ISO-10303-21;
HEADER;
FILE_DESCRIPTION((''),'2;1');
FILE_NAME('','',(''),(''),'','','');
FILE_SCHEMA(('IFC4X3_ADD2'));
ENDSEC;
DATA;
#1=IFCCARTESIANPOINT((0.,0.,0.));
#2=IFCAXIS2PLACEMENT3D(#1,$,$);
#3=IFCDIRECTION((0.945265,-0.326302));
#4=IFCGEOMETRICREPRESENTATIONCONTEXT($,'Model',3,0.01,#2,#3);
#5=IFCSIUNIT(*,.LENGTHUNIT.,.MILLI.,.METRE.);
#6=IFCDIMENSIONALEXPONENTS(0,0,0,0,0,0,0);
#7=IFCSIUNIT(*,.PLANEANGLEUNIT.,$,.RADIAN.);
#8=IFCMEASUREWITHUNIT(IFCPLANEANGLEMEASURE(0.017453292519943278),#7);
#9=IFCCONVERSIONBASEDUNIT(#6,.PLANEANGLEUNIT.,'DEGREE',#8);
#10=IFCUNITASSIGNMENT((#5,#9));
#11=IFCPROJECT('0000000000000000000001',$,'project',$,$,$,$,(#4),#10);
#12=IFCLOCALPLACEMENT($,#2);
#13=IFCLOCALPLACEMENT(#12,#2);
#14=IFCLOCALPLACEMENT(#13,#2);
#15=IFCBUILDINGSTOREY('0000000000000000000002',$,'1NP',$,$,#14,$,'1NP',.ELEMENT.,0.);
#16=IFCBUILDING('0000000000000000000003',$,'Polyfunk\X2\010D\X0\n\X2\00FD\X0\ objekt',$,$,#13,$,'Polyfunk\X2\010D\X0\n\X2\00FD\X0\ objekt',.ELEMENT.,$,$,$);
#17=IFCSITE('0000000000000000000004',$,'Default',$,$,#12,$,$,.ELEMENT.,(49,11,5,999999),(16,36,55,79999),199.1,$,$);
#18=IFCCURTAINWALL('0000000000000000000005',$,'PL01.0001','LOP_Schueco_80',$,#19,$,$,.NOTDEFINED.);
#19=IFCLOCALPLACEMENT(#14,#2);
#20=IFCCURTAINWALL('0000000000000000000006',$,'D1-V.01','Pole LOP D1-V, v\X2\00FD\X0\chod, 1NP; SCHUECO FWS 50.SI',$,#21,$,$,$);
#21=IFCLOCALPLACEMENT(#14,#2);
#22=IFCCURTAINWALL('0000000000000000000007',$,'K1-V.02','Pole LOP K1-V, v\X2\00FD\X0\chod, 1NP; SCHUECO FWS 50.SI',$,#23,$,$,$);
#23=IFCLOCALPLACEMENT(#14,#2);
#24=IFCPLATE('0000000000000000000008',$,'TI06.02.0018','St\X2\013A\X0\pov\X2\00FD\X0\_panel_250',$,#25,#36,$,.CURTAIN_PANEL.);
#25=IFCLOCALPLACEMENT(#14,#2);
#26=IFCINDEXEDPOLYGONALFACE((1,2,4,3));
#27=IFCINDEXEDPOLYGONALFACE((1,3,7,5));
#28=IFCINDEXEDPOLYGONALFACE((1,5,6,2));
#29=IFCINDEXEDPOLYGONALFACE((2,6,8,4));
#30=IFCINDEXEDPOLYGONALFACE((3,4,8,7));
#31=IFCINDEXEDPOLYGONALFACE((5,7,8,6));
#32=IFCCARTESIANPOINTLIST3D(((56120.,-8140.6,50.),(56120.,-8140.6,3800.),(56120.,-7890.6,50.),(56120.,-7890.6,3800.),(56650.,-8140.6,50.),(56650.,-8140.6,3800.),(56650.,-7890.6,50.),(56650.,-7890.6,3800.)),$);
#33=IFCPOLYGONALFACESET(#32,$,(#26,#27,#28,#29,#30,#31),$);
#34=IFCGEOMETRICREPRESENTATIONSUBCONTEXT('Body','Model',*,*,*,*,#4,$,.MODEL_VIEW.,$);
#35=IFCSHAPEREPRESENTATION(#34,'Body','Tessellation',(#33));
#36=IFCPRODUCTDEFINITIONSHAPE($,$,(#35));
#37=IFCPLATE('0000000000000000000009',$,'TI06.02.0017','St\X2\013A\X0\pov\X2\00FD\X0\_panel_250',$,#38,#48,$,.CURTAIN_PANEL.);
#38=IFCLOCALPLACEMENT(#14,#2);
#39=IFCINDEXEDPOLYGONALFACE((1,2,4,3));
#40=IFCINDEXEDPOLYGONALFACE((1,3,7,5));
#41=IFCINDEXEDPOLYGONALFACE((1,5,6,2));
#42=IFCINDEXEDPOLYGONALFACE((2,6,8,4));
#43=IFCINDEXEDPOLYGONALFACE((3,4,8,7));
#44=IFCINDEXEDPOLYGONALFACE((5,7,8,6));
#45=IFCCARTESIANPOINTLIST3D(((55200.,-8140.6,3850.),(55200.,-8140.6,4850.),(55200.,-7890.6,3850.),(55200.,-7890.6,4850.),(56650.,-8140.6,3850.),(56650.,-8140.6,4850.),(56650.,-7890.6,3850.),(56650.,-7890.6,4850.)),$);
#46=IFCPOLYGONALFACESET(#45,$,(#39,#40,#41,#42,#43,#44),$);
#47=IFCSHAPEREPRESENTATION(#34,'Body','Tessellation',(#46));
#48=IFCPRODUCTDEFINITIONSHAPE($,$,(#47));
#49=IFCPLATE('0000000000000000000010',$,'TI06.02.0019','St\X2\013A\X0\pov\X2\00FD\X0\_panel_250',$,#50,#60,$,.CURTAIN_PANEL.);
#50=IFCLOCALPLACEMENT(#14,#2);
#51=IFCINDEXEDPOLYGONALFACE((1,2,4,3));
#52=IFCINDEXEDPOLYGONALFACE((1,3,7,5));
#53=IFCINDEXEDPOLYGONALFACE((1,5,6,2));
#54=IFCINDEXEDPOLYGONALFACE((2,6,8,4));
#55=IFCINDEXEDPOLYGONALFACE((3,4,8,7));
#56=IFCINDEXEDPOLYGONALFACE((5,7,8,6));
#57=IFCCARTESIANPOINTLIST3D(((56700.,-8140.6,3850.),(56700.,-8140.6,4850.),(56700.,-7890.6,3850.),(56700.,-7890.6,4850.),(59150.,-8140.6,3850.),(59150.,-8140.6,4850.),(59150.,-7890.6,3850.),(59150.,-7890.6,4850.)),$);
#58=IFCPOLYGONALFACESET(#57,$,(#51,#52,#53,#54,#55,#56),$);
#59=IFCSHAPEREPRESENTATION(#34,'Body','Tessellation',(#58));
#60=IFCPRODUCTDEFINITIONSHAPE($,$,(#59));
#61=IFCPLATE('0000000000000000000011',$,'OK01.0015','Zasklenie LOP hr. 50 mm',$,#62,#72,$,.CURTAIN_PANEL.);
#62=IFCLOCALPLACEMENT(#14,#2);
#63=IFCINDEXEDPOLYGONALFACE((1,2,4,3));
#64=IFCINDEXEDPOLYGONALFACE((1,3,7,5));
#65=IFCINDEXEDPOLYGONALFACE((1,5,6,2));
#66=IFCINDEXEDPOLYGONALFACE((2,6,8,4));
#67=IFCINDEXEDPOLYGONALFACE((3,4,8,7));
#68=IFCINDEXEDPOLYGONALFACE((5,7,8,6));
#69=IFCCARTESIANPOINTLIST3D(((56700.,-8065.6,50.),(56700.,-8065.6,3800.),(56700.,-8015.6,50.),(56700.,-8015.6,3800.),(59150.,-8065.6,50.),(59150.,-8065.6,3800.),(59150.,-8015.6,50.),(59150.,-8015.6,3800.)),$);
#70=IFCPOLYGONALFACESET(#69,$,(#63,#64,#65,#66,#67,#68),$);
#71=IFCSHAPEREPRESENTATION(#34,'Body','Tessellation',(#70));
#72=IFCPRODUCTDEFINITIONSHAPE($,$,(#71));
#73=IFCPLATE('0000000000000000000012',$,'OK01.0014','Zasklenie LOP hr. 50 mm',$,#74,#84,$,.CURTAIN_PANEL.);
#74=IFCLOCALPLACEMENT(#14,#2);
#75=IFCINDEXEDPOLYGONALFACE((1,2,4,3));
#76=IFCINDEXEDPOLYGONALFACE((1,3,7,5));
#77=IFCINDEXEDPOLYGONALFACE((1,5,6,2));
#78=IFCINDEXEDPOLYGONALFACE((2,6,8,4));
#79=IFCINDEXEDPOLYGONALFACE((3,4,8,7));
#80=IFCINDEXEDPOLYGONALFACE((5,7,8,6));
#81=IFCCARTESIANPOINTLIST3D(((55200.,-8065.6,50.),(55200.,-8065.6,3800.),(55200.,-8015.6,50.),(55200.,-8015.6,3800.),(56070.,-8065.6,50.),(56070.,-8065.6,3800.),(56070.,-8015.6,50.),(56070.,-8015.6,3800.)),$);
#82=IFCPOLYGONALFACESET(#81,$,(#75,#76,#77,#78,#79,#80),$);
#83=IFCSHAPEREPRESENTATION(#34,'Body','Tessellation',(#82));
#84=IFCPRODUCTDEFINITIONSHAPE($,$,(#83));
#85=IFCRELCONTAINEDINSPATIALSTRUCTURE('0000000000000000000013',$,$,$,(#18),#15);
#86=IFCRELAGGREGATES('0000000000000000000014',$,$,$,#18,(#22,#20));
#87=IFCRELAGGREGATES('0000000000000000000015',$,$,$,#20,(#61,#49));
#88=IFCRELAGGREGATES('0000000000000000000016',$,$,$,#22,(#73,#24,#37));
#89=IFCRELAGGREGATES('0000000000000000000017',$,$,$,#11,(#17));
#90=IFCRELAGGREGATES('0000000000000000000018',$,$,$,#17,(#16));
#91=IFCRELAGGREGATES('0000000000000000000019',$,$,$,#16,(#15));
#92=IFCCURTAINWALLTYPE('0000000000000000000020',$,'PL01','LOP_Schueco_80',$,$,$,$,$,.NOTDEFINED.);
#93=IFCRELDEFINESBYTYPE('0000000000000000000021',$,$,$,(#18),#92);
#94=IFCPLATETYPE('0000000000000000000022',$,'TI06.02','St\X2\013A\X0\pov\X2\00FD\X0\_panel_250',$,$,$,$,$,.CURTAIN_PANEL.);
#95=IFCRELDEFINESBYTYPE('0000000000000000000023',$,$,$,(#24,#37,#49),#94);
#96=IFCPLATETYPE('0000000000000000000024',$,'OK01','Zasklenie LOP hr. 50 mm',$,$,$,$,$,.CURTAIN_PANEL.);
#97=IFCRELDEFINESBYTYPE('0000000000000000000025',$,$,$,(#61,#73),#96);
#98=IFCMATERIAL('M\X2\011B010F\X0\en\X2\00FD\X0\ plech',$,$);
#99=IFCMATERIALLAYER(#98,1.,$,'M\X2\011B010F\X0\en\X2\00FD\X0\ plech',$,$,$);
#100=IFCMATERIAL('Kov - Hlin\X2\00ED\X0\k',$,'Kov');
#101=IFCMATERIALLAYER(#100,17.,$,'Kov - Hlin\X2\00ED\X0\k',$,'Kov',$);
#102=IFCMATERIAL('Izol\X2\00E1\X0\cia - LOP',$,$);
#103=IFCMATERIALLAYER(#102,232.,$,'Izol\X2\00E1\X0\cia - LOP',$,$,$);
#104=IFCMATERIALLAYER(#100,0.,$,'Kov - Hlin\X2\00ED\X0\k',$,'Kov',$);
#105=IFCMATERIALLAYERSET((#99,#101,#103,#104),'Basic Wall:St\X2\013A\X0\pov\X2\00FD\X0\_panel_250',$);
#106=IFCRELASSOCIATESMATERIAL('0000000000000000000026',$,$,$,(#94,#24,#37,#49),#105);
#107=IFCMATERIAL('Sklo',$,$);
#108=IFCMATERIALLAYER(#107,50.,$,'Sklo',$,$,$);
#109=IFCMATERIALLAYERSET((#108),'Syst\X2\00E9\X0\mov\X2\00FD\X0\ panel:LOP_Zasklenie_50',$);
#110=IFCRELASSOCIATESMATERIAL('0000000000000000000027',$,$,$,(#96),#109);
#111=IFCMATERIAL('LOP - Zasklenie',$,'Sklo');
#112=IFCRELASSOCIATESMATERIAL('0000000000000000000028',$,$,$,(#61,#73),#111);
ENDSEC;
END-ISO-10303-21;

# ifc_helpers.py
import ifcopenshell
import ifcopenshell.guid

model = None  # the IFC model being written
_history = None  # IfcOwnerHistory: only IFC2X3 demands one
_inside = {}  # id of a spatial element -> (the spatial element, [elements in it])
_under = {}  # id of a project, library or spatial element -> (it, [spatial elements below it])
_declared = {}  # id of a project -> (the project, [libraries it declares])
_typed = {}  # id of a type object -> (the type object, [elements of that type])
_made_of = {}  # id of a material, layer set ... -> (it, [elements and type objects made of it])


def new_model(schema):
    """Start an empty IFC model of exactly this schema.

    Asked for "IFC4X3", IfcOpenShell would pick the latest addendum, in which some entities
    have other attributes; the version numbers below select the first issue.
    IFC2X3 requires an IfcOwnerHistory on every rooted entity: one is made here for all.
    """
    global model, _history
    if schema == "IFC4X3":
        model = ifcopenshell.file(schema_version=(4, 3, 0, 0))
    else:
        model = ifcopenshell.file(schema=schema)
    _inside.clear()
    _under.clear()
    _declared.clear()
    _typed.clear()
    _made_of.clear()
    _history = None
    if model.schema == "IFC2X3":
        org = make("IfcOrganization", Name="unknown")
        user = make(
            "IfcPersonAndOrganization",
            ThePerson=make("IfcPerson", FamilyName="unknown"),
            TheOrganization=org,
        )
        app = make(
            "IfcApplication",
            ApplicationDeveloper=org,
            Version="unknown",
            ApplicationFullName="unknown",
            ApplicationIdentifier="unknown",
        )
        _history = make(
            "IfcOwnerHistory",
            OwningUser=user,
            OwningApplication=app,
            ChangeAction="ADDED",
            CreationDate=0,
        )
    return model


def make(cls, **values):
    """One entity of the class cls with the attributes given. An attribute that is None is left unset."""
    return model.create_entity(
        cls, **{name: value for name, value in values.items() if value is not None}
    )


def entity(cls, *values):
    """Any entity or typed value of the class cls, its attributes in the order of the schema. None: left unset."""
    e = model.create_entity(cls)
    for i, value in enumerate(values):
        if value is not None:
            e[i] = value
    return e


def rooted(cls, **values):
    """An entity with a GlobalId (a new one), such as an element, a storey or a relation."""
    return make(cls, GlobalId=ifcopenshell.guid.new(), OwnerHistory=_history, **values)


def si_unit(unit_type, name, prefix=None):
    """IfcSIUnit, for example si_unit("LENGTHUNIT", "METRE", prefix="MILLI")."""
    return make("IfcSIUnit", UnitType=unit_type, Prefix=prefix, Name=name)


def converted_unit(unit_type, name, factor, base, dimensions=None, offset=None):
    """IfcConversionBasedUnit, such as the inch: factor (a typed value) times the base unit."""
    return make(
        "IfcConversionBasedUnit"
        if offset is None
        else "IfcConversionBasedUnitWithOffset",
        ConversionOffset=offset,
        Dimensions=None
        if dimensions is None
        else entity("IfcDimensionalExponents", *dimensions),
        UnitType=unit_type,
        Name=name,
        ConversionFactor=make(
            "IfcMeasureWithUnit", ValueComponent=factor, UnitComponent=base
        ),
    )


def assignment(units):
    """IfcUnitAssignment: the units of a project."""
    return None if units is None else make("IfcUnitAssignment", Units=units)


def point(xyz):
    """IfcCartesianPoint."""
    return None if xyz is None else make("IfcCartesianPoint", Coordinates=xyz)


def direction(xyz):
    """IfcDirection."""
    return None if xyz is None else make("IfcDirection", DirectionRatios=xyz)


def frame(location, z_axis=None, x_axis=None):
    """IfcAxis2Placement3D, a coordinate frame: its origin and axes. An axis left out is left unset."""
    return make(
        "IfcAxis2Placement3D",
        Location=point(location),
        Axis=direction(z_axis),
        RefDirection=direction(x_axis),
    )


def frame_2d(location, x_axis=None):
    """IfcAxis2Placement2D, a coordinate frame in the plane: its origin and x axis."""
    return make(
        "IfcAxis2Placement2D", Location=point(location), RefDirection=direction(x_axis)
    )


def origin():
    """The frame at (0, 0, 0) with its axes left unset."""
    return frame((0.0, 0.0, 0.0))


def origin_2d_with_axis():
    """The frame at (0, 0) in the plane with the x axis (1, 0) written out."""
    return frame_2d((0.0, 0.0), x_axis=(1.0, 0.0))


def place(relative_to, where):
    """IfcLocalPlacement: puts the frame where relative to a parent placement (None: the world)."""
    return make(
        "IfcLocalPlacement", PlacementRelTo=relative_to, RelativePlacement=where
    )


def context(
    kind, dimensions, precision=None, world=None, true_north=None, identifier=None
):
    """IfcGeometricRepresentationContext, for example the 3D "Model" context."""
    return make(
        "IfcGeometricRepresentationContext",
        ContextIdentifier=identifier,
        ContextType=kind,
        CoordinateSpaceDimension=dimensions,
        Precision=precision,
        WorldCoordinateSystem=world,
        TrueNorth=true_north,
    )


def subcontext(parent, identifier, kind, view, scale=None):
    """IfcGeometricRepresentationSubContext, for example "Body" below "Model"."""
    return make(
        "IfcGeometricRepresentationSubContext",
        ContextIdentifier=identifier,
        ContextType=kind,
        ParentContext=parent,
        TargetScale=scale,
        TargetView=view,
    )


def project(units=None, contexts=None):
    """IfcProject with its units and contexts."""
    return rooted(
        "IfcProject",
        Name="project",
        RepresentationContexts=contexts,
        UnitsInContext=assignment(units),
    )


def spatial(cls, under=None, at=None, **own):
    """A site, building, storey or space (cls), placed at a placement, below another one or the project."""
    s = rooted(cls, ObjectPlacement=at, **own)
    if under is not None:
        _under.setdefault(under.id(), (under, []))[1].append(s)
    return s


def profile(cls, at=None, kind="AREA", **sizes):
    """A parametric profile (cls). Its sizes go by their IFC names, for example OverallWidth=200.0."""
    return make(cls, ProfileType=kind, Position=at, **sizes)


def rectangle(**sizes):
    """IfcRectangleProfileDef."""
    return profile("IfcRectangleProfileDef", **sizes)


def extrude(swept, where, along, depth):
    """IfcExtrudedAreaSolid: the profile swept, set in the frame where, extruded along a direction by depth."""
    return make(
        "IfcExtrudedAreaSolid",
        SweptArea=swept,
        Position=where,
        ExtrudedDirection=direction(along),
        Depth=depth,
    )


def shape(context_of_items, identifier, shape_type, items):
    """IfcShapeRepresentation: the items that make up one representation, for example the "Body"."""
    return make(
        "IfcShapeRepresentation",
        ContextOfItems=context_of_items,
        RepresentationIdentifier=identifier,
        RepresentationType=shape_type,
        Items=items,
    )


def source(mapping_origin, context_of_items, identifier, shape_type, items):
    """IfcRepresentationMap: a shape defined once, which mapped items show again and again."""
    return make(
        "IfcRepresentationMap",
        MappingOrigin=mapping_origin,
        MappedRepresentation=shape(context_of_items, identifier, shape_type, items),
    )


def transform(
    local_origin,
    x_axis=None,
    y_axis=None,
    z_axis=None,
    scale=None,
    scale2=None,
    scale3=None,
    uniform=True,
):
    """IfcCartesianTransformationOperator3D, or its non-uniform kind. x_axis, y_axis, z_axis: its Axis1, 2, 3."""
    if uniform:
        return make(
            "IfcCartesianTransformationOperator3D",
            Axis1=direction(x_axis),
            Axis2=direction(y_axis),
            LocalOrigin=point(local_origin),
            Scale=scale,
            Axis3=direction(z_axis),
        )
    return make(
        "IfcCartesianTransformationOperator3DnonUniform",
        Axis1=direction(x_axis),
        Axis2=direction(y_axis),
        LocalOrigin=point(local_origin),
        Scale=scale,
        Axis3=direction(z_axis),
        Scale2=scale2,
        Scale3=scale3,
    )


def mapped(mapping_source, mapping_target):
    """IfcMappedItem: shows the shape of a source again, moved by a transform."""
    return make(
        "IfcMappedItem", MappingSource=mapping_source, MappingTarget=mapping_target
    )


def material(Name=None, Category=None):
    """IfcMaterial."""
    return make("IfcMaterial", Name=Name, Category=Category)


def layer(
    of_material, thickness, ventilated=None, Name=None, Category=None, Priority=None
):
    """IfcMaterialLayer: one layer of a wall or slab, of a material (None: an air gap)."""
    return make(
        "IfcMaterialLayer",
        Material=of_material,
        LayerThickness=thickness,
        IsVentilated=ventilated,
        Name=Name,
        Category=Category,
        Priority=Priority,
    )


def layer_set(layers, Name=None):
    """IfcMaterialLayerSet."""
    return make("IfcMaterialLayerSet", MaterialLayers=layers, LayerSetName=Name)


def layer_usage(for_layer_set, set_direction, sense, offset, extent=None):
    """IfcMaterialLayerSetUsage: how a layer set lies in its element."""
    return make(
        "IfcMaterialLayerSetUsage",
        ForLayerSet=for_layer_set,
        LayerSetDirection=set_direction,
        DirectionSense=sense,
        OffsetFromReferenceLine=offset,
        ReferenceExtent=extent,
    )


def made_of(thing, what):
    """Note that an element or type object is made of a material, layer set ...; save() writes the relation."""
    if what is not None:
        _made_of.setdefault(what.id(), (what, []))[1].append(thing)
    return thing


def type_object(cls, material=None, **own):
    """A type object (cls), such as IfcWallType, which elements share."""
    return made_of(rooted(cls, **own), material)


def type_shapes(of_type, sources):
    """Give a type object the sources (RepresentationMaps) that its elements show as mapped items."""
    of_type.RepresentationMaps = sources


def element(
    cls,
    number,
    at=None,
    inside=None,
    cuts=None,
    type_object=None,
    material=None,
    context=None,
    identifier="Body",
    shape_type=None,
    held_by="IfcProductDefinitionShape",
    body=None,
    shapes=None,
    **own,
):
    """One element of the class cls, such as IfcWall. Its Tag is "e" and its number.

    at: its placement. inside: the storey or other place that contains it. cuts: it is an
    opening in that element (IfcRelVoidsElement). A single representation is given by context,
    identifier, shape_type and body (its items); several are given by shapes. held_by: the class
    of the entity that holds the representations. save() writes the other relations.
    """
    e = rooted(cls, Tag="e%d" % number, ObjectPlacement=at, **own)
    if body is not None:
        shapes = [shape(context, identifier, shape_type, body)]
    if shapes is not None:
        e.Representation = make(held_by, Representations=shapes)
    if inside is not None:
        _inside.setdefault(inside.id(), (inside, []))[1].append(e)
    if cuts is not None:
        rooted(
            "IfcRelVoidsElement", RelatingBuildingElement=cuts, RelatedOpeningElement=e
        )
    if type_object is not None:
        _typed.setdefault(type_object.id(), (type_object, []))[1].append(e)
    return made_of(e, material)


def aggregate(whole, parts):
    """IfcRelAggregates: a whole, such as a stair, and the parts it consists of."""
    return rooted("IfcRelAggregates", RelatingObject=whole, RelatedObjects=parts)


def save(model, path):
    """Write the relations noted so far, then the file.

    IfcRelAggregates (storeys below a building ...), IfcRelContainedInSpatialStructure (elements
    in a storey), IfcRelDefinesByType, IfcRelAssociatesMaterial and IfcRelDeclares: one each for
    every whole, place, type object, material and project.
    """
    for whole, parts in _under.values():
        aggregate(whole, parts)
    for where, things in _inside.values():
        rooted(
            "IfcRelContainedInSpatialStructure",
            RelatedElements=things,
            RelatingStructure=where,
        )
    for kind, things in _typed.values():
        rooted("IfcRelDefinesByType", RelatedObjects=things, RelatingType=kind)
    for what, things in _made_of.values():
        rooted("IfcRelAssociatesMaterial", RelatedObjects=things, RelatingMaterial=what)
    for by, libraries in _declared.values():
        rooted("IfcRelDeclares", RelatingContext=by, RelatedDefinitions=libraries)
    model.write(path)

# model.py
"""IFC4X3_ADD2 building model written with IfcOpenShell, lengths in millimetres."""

from ifc_helpers import new_model, entity, si_unit, converted_unit, direction, frame, frame_2d, origin, origin_2d_with_axis, place, context, subcontext, project, spatial, rectangle, extrude, source, transform, mapped, material, layer, layer_set, layer_usage, type_object, type_shapes, element, aggregate, save


model = new_model("IFC4X3_ADD2")

# Units and contexts
model_context = context("Model", 3, precision=0.01, world=origin(), true_north=direction((0.945265, -0.326302)))
body_context = subcontext(model_context, "Body", "Model", "MODEL_VIEW")
ifc_project = project(units=[si_unit("LENGTHUNIT", "METRE", prefix="MILLI"), converted_unit("PLANEANGLEUNIT", "DEGREE", entity("IfcPlaneAngleMeasure", 0.017453292519943278), si_unit("PLANEANGLEUNIT", "RADIAN"), dimensions=[0, 0, 0, 0, 0, 0, 0])], contexts=[model_context])

# Site, building, storey
site_placement = place(None, origin())
site = spatial("IfcSite", under=ifc_project, at=site_placement, Name="Default", CompositionType="ELEMENT", RefLatitude=(49, 11, 5, 999999), RefLongitude=(16, 36, 55, 79999), RefElevation=199.1)
building_placement = place(site_placement, origin())
building = spatial("IfcBuilding", under=site, at=building_placement, Name="Polyfunkčný objekt", LongName="Polyfunkčný objekt", CompositionType="ELEMENT")
storey_placement = place(building_placement, origin())
storey = spatial("IfcBuildingStorey", under=building, at=storey_placement, Name="1NP", LongName="1NP", CompositionType="ELEMENT", Elevation=0.0)

# Curtain walls, plates
curtain_wall_type = type_object("IfcCurtainWallType", Name="PL01", Description="LOP_Schueco_80", PredefinedType="NOTDEFINED")
curtain_wall_1_placement = place(storey_placement, origin())
curtain_wall_1 = element("IfcCurtainWall", 1, at=curtain_wall_1_placement, inside=storey, type_object=curtain_wall_type, Name="PL01.0001", Description="LOP_Schueco_80", PredefinedType="NOTDEFINED")
curtain_wall_2 = element("IfcCurtainWall", 2, Name="D1-V.01", Description="Pole LOP D1-V, východ, 1NP; SCHUECO FWS 50.SI")
curtain_wall_3 = element("IfcCurtainWall", 3, Name="K1-V.02", Description="Pole LOP K1-V, východ, 1NP; SCHUECO FWS 50.SI")
aggregate(curtain_wall_1, [curtain_wall_3, curtain_wall_2])
ifc_material_1 = material(Name="Měďený plech")
ifc_layer_1 = layer(ifc_material_1, 1.0, Name="Měďený plech")
ifc_material_2 = material(Name="Kov - Hliník", Category="Kov")
ifc_layer_2 = layer(ifc_material_2, 17.0, Name="Kov - Hliník", Category="Kov")
ifc_material_3 = material(Name="Izolácia - LOP")
ifc_layer_3 = layer(ifc_material_3, 232.0, Name="Izolácia - LOP")
ifc_layer_4 = layer(ifc_material_2, 0.0, Name="Kov - Hliník", Category="Kov")
ifc_layer_set_1 = layer_set([ifc_layer_1, ifc_layer_2, ifc_layer_3, ifc_layer_4], Name="Basic Wall:Stĺpový_panel_250")
ifc_layer_usage_1 = layer_usage(ifc_layer_set_1, "AXIS2", "POSITIVE", -125.0)
plate_type_1 = type_object("IfcPlateType", Name="TI06.02", Description="Stĺpový_panel_250", PredefinedType="CURTAIN_PANEL", material=ifc_layer_set_1)
plate_1_placement = place(storey_placement, frame((56120.0, -8015.6, 50.0)))
plate_1 = element("IfcPlate", 4, at=plate_1_placement, type_object=plate_type_1, material=ifc_layer_usage_1, Name="TI06.02.0018", Description="Stĺpový_panel_250", PredefinedType="CURTAIN_PANEL", context=body_context, shape_type="SweptSolid", body=[
    extrude(rectangle(XDim=250.0, YDim=530.0, at=frame_2d((0.0, 0.0), x_axis=(1.0, 0.0))), frame((265.0, 0.0, 0.0), z_axis=(0.0, 0.0, 1.0), x_axis=(0.0, 1.0, 0.0)), (0.0, 0.0, 1.0), 3750.0),
])
ifc_layer_usage_2 = layer_usage(ifc_layer_set_1, "AXIS2", "POSITIVE", -125.0)
plate_2_placement = place(storey_placement, frame((55200.0, -8015.6, 3850.0)))
plate_2 = element("IfcPlate", 5, at=plate_2_placement, type_object=plate_type_1, material=ifc_layer_usage_2, Name="TI06.02.0017", Description="Stĺpový_panel_250", PredefinedType="CURTAIN_PANEL", context=body_context, shape_type="SweptSolid", body=[
    extrude(rectangle(XDim=250.0, YDim=1450.0, at=frame_2d((0.0, 0.0), x_axis=(1.0, 0.0))), frame((725.0, 0.0, 0.0), z_axis=(0.0, 0.0, 1.0), x_axis=(0.0, 1.0, 0.0)), (0.0, 0.0, 1.0), 1000.0),
])
ifc_layer_usage_3 = layer_usage(ifc_layer_set_1, "AXIS2", "POSITIVE", -125.0)
plate_3_placement = place(storey_placement, frame((56700.0, -8015.6, 3850.0)))
plate_3 = element("IfcPlate", 6, at=plate_3_placement, type_object=plate_type_1, material=ifc_layer_usage_3, Name="TI06.02.0019", Description="Stĺpový_panel_250", PredefinedType="CURTAIN_PANEL", context=body_context, shape_type="SweptSolid", body=[
    extrude(rectangle(XDim=250.0, YDim=2450.0, at=origin_2d_with_axis()), frame((1225.0, 0.0, 0.0), z_axis=(0.0, 0.0, 1.0), x_axis=(0.0, 1.0, 0.0)), (0.0, 0.0, 1.0), 1000.0),
])
ifc_material_4 = material(Name="LOP - Zasklenie", Category="Sklo")
ifc_material_5 = material(Name="Sklo")
ifc_layer_5 = layer(ifc_material_5, 50.0, Name="Sklo")
ifc_layer_set_2 = layer_set([ifc_layer_5], Name="Systémový panel:LOP_Zasklenie_50")
plate_type_2 = type_object("IfcPlateType", Name="OK01", Description="Zasklenie LOP hr. 50 mm", PredefinedType="CURTAIN_PANEL", material=ifc_layer_set_2)
shared_shape_1 = source(origin(), body_context, "Body", "SweptSolid", [
    extrude(rectangle(XDim=3750.0, YDim=2450.0, at=frame_2d((-331.2, 0.0), x_axis=(1.0, 0.0))), frame((0.0, -50.0, 2206.2), z_axis=(0.0, 1.0, 0.0), x_axis=(0.0, 0.0, 1.0)), (0.0, 0.0, 1.0), 50.0),
])
plate_4_placement = place(curtain_wall_1_placement, frame((57925.0, -8015.6, 50.0)))
plate_4 = element("IfcPlate", 7, at=plate_4_placement, type_object=plate_type_2, material=ifc_material_4, Name="OK01.0015", Description="Zasklenie LOP hr. 50 mm", PredefinedType="CURTAIN_PANEL", context=body_context, shape_type="MappedRepresentation", body=[
    mapped(shared_shape_1, transform((0.0, 0.0, 0.0), scale=1.0)),
])
aggregate(curtain_wall_2, [plate_4, plate_3])
shared_shape_2 = source(origin(), body_context, "Body", "SweptSolid", [
    extrude(rectangle(XDim=3750.0, YDim=870.0, at=frame_2d((-331.2, 0.0), x_axis=(1.0, 0.0))), frame((0.0, -50.0, 2206.2), z_axis=(0.0, 1.0, 0.0), x_axis=(0.0, 0.0, 1.0)), (0.0, 0.0, 1.0), 50.0),
])
type_shapes(plate_type_2, [shared_shape_1, shared_shape_2])
plate_5_placement = place(curtain_wall_1_placement, frame((55635.0, -8015.6, 50.0)))
plate_5 = element("IfcPlate", 8, at=plate_5_placement, type_object=plate_type_2, material=ifc_material_4, Name="OK01.0014", Description="Zasklenie LOP hr. 50 mm", PredefinedType="CURTAIN_PANEL", context=body_context, shape_type="MappedRepresentation", body=[
    mapped(shared_shape_2, transform((0.0, 0.0, 0.0), scale=1.0)),
])
aggregate(curtain_wall_3, [plate_5, plate_1, plate_2])

save(model, "model.ifc")
